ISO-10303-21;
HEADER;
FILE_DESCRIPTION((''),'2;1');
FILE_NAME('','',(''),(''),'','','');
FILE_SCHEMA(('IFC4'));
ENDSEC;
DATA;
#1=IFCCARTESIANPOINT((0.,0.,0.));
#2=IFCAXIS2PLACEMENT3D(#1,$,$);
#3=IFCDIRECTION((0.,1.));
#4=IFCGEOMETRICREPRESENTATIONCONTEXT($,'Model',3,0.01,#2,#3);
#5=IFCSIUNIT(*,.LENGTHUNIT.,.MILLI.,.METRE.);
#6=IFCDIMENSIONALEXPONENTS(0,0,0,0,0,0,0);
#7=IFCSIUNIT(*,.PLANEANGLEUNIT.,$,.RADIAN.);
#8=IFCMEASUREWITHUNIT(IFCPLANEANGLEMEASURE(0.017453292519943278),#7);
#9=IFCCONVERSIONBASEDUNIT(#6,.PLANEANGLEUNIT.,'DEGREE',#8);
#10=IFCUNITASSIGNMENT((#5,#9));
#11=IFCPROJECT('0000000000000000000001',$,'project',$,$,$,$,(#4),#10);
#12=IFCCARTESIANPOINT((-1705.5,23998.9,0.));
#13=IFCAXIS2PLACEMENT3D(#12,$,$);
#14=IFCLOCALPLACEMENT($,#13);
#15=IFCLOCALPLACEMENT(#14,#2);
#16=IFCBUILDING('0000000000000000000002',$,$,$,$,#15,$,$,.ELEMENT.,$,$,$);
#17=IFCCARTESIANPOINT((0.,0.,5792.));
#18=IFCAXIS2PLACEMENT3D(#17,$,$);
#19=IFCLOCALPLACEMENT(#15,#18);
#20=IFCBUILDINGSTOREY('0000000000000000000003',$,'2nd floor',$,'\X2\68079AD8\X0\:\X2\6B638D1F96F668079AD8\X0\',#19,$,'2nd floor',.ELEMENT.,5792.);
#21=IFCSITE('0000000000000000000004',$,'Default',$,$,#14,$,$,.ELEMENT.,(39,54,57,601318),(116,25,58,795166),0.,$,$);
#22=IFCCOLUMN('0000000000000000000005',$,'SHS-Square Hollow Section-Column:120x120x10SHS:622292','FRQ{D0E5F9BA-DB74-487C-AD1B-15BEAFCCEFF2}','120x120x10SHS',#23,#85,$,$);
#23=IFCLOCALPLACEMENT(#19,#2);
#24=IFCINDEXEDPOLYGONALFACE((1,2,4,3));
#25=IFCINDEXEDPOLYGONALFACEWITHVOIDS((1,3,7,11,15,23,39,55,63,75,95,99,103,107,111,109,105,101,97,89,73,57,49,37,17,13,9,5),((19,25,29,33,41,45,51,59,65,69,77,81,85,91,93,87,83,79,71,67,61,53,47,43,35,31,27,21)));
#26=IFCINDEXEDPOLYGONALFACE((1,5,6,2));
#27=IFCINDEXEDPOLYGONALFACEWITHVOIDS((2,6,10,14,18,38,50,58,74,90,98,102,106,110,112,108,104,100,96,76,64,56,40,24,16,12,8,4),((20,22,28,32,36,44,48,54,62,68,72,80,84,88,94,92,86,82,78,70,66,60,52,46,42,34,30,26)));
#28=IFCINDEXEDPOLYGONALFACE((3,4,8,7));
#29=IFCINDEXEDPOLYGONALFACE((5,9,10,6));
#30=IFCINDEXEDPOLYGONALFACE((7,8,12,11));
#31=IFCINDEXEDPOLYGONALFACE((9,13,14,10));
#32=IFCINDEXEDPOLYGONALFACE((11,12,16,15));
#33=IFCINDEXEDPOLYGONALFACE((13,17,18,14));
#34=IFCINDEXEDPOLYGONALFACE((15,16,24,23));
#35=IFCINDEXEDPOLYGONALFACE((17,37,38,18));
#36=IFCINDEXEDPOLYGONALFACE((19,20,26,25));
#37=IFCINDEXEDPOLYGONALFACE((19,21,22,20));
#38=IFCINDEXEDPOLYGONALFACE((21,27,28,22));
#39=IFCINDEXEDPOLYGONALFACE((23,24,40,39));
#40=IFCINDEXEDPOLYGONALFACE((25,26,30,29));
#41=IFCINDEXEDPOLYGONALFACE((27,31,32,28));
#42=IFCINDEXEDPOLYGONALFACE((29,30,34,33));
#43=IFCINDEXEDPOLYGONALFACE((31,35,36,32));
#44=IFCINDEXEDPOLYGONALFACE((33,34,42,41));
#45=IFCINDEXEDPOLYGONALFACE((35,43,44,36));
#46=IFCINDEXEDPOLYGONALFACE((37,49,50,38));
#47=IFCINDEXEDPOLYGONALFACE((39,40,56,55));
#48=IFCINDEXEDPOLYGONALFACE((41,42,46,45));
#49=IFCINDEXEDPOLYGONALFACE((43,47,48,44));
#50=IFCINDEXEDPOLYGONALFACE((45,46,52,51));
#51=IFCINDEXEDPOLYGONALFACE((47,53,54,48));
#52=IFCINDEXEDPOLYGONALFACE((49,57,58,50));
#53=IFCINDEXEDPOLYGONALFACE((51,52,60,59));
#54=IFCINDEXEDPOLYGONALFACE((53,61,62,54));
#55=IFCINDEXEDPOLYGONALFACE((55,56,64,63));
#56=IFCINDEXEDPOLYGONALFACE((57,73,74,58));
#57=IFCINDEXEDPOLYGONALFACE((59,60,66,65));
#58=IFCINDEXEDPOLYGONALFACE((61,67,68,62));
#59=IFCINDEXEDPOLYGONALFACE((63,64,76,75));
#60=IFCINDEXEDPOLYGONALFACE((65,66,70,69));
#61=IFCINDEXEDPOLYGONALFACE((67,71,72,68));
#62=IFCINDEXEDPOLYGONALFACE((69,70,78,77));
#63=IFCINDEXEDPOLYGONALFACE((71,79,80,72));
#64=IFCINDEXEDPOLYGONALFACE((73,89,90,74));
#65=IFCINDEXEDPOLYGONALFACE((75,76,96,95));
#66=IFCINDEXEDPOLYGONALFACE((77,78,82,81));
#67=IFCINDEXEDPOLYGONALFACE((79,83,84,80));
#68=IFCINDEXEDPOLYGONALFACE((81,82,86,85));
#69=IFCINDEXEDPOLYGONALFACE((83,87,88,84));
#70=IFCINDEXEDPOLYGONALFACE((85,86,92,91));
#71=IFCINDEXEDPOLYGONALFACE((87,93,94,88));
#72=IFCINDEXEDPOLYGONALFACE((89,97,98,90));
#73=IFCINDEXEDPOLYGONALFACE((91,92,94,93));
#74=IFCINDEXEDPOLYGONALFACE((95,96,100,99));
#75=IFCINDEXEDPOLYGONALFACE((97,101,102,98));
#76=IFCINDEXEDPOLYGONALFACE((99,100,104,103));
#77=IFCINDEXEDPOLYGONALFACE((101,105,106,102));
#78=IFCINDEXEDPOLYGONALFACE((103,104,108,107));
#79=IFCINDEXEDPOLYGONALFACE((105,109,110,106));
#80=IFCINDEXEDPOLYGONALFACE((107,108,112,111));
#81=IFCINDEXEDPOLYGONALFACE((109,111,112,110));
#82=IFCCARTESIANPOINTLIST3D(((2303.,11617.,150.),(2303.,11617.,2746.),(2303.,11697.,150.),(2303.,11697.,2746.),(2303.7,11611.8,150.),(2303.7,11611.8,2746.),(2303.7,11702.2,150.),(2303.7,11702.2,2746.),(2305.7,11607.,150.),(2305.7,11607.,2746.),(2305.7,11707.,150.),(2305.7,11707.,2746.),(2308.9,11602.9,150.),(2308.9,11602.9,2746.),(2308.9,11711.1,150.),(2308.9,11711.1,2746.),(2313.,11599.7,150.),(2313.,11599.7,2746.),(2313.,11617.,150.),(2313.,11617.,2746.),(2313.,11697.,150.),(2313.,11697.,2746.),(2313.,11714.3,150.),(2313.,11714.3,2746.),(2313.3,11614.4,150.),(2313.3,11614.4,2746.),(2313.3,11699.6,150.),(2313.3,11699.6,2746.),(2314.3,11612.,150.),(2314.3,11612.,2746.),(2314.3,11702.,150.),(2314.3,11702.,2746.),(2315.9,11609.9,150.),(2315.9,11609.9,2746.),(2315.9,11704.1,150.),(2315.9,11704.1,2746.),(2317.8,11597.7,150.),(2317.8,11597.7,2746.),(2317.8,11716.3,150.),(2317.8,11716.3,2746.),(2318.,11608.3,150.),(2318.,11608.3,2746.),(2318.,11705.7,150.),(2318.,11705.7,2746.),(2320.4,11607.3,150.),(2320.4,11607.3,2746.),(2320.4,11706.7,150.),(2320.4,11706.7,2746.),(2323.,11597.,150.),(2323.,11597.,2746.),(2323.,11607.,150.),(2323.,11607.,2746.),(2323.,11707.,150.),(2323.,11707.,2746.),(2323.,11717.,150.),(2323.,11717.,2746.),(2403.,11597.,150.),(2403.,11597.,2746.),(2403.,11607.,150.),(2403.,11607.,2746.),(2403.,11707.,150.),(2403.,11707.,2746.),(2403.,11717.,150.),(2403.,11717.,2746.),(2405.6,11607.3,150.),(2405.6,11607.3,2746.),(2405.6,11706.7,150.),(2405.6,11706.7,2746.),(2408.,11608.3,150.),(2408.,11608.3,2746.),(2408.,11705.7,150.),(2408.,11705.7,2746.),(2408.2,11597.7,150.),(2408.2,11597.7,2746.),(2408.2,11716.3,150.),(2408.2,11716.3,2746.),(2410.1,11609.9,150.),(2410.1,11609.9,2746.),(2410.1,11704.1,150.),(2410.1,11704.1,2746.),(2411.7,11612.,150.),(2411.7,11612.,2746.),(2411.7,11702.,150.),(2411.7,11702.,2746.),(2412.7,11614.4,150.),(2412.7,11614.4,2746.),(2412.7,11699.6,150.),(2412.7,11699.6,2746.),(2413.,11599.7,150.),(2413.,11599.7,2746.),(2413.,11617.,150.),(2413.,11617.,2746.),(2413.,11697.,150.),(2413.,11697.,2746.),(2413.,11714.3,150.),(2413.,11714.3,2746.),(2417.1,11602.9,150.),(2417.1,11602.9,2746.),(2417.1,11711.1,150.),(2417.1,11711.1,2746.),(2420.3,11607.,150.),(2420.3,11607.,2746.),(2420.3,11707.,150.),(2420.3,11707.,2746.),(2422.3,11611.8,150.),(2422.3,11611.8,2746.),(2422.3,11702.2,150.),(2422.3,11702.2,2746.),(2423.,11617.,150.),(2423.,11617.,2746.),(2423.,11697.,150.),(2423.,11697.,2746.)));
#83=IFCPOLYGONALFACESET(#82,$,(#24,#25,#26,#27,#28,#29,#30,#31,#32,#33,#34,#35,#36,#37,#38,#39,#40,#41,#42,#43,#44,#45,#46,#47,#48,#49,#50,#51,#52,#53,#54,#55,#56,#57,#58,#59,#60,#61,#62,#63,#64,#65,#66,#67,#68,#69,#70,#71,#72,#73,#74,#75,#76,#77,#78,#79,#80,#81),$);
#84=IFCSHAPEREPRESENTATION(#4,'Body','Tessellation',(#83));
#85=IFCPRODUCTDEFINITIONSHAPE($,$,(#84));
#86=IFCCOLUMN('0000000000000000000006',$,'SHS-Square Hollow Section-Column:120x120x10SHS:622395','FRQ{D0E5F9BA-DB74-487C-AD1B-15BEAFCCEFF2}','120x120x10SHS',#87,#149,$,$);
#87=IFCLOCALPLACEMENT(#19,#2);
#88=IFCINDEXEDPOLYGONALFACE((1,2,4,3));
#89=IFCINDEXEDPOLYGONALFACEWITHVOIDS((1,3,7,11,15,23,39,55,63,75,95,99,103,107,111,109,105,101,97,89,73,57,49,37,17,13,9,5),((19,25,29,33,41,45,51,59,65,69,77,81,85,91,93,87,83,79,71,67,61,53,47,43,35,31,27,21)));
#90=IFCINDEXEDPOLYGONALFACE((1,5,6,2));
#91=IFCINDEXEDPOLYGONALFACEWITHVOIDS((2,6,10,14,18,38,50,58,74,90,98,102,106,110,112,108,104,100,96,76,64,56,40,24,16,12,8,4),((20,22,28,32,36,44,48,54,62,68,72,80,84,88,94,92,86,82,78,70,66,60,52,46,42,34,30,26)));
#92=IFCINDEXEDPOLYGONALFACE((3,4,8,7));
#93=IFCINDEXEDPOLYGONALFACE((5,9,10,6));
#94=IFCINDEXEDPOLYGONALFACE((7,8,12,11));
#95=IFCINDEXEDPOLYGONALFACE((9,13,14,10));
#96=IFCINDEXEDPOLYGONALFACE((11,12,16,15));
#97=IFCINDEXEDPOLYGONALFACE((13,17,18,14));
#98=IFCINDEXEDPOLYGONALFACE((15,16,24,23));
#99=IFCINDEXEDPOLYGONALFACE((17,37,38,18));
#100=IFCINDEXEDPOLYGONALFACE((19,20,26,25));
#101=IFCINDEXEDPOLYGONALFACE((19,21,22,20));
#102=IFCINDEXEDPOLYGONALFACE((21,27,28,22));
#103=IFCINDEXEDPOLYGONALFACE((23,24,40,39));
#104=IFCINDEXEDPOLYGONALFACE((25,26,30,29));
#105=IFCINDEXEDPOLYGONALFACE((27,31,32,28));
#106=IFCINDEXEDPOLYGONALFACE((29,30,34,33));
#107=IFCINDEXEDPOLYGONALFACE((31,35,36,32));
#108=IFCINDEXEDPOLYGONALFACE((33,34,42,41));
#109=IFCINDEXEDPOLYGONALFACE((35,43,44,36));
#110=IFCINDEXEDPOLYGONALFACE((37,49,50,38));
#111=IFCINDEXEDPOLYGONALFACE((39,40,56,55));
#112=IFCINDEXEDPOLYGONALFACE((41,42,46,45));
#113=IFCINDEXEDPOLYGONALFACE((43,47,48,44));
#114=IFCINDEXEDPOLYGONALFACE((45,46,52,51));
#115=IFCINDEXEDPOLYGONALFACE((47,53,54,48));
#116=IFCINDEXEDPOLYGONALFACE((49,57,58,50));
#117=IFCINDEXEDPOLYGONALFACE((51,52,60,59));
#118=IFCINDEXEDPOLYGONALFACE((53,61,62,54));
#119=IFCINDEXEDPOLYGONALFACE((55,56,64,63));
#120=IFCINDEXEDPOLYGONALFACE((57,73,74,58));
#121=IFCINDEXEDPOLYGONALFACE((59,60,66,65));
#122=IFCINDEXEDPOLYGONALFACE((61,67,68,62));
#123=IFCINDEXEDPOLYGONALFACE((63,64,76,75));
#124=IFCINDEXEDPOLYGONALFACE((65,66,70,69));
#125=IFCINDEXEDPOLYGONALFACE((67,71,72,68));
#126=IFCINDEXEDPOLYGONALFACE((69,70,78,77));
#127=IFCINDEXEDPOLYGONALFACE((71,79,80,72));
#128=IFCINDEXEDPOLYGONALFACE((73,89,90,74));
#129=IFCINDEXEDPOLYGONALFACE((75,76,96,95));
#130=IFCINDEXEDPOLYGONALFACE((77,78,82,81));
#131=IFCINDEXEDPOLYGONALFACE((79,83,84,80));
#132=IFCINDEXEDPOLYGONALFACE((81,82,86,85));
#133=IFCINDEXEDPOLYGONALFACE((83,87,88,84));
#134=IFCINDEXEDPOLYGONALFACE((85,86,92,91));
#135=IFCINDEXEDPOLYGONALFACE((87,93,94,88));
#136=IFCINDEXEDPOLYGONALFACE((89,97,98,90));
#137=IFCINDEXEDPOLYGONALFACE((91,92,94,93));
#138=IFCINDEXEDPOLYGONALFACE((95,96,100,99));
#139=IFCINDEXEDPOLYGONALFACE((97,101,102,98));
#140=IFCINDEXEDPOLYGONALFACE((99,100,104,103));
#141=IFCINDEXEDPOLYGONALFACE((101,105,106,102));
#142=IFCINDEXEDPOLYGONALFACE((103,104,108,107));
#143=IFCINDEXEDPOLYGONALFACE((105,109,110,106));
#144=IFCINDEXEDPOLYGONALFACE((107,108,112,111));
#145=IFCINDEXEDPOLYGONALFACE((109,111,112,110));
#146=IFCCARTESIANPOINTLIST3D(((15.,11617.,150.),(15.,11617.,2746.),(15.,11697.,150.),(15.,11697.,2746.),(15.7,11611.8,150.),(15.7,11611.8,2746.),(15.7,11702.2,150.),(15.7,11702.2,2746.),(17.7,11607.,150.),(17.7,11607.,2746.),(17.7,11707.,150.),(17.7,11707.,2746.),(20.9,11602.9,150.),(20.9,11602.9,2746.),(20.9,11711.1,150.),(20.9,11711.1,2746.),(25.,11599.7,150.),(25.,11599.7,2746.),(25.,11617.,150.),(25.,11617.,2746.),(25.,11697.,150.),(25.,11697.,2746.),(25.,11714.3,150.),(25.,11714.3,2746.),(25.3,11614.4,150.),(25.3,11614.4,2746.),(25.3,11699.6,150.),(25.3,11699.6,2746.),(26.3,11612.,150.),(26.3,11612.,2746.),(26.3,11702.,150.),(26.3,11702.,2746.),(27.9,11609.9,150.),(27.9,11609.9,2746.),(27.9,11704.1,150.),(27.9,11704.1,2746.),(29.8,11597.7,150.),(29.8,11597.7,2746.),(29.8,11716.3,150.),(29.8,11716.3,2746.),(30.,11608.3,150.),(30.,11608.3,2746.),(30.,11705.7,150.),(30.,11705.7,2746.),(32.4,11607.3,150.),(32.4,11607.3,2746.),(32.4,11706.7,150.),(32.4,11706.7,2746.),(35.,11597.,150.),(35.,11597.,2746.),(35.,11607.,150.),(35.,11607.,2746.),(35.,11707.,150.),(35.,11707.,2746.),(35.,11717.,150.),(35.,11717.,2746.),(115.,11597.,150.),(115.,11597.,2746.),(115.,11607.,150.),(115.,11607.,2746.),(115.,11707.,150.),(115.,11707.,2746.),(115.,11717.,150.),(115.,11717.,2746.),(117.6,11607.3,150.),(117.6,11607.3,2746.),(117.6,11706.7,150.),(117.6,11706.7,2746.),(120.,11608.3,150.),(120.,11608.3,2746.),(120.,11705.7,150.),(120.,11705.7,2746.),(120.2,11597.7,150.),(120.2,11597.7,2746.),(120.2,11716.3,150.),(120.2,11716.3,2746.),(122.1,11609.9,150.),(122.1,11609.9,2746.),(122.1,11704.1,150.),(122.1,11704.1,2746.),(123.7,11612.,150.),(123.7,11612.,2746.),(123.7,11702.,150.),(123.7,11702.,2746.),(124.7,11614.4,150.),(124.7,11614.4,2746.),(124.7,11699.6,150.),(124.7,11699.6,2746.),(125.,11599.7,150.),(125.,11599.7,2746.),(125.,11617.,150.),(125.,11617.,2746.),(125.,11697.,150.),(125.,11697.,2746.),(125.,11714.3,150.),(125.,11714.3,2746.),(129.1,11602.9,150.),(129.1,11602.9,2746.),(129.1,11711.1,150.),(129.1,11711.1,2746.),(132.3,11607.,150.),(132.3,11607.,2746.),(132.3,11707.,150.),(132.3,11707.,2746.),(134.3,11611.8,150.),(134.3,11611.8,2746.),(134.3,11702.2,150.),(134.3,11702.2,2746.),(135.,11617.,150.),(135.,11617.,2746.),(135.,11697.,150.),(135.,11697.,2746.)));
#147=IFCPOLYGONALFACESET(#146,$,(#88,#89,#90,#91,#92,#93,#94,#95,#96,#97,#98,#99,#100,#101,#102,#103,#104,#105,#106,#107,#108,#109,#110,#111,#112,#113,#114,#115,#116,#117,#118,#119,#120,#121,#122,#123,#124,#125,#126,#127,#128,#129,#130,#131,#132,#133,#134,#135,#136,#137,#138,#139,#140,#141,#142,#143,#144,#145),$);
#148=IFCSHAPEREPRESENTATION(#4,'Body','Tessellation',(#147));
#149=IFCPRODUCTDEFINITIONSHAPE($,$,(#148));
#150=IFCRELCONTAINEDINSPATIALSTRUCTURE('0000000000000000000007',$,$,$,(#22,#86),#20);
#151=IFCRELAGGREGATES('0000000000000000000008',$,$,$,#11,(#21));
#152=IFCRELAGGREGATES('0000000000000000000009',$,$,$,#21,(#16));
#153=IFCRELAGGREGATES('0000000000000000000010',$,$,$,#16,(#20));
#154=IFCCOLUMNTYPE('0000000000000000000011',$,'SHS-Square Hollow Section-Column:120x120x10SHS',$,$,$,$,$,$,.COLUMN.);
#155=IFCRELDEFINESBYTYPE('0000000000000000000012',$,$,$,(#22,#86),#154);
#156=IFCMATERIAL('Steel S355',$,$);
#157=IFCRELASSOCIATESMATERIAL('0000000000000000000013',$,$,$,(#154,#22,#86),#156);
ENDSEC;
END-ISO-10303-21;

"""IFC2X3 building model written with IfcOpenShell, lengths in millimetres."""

from ifc_helpers import new_model, entity, si_unit, converted_unit, direction, frame, origin, origin_2d, place, context, project, spatial, hollow_rectangle, extrude, clip, halfspace, material, type_object, element, save


model = new_model("IFC2X3")

# Units and contexts
model_context = context("Model", 3, precision=0.01, world=origin(), true_north=direction((0.0, 1.0)))
ifc_project = project(units=[si_unit("LENGTHUNIT", "METRE", prefix="MILLI"), converted_unit("PLANEANGLEUNIT", "DEGREE", entity("IfcPlaneAngleMeasure", 0.017453292519943278), si_unit("PLANEANGLEUNIT", "RADIAN"), dimensions=[0, 0, 0, 0, 0, 0, 0])], contexts=[model_context])

# Site, building, storey
site_placement = place(None, frame((-1705.5, 23998.9, 0.0)))
site = spatial("IfcSite", under=ifc_project, at=site_placement, Name="Default", CompositionType="ELEMENT", RefLatitude=(39, 54, 57, 601318), RefLongitude=(116, 25, 58, 795166), RefElevation=0.0)
building_placement = place(site_placement, origin())
building = spatial("IfcBuilding", under=site, at=building_placement, CompositionType="ELEMENT")
storey_placement = place(building_placement, frame((0.0, 0.0, 5792.0)))
storey = spatial("IfcBuildingStorey", under=building, at=storey_placement, Name="2nd floor", ObjectType="标高:正负零标高", LongName="2nd floor", CompositionType="ELEMENT", Elevation=5792.0)

# Columns
ifc_material_1 = material(Name="Steel S355")
column_type_1 = type_object("IfcColumnType", Name="SHS-Square Hollow Section-Column:120x120x10SHS", PredefinedType="COLUMN", material=ifc_material_1)
column_1_placement = place(storey_placement, frame((2363.0, 11657.0, 2830.9), z_axis=(0.0, 0.0, 1.0), x_axis=(0.0, -1.0, 0.0)))
element("IfcColumn", 1, at=column_1_placement, inside=storey, type_object=column_type_1, material=ifc_material_1, Name="SHS-Square Hollow Section-Column:120x120x10SHS:622292", Description="FRQ{D0E5F9BA-DB74-487C-AD1B-15BEAFCCEFF2}", ObjectType="120x120x10SHS", context=model_context, shape_type="Clipping", body=[
    clip(clip(extrude(hollow_rectangle(XDim=120.0, YDim=120.0, WallThickness=10.0, InnerFilletRadius=10.0, OuterFilletRadius=20.0, at=origin_2d()), origin(), (0.0, 0.0, -1.0), 2765.7), halfspace(frame((11657.0, -2363.0, -84.9), z_axis=(0.0, 0.0, -1.0), x_axis=(0.0, -1.0, 0.0)), True)), halfspace(frame((11657.0, -2363.0, -2680.9), z_axis=(0.0, 0.0, 1.0), x_axis=(0.0, 1.0, 0.0)), True)),
])
column_2_placement = place(storey_placement, frame((75.0, 11657.0, 2830.9), z_axis=(0.0, 0.0, 1.0), x_axis=(0.0, -1.0, 0.0)))
element("IfcColumn", 2, at=column_2_placement, inside=storey, type_object=column_type_1, material=ifc_material_1, Name="SHS-Square Hollow Section-Column:120x120x10SHS:622395", Description="FRQ{D0E5F9BA-DB74-487C-AD1B-15BEAFCCEFF2}", ObjectType="120x120x10SHS", context=model_context, shape_type="Clipping", body=[
    clip(clip(extrude(hollow_rectangle(XDim=120.0, YDim=120.0, WallThickness=10.0, InnerFilletRadius=10.0, OuterFilletRadius=20.0, at=origin_2d()), origin(), (0.0, 0.0, -1.0), 2765.7), halfspace(frame((11657.0, -75.0, -84.9), z_axis=(0.0, 0.0, -1.0), x_axis=(0.0, -1.0, 0.0)), True)), halfspace(frame((11657.0, -75.0, -2680.9), z_axis=(0.0, 0.0, 1.0), x_axis=(0.0, 1.0, 0.0)), True)),
])

save(model, "model.ifc")
